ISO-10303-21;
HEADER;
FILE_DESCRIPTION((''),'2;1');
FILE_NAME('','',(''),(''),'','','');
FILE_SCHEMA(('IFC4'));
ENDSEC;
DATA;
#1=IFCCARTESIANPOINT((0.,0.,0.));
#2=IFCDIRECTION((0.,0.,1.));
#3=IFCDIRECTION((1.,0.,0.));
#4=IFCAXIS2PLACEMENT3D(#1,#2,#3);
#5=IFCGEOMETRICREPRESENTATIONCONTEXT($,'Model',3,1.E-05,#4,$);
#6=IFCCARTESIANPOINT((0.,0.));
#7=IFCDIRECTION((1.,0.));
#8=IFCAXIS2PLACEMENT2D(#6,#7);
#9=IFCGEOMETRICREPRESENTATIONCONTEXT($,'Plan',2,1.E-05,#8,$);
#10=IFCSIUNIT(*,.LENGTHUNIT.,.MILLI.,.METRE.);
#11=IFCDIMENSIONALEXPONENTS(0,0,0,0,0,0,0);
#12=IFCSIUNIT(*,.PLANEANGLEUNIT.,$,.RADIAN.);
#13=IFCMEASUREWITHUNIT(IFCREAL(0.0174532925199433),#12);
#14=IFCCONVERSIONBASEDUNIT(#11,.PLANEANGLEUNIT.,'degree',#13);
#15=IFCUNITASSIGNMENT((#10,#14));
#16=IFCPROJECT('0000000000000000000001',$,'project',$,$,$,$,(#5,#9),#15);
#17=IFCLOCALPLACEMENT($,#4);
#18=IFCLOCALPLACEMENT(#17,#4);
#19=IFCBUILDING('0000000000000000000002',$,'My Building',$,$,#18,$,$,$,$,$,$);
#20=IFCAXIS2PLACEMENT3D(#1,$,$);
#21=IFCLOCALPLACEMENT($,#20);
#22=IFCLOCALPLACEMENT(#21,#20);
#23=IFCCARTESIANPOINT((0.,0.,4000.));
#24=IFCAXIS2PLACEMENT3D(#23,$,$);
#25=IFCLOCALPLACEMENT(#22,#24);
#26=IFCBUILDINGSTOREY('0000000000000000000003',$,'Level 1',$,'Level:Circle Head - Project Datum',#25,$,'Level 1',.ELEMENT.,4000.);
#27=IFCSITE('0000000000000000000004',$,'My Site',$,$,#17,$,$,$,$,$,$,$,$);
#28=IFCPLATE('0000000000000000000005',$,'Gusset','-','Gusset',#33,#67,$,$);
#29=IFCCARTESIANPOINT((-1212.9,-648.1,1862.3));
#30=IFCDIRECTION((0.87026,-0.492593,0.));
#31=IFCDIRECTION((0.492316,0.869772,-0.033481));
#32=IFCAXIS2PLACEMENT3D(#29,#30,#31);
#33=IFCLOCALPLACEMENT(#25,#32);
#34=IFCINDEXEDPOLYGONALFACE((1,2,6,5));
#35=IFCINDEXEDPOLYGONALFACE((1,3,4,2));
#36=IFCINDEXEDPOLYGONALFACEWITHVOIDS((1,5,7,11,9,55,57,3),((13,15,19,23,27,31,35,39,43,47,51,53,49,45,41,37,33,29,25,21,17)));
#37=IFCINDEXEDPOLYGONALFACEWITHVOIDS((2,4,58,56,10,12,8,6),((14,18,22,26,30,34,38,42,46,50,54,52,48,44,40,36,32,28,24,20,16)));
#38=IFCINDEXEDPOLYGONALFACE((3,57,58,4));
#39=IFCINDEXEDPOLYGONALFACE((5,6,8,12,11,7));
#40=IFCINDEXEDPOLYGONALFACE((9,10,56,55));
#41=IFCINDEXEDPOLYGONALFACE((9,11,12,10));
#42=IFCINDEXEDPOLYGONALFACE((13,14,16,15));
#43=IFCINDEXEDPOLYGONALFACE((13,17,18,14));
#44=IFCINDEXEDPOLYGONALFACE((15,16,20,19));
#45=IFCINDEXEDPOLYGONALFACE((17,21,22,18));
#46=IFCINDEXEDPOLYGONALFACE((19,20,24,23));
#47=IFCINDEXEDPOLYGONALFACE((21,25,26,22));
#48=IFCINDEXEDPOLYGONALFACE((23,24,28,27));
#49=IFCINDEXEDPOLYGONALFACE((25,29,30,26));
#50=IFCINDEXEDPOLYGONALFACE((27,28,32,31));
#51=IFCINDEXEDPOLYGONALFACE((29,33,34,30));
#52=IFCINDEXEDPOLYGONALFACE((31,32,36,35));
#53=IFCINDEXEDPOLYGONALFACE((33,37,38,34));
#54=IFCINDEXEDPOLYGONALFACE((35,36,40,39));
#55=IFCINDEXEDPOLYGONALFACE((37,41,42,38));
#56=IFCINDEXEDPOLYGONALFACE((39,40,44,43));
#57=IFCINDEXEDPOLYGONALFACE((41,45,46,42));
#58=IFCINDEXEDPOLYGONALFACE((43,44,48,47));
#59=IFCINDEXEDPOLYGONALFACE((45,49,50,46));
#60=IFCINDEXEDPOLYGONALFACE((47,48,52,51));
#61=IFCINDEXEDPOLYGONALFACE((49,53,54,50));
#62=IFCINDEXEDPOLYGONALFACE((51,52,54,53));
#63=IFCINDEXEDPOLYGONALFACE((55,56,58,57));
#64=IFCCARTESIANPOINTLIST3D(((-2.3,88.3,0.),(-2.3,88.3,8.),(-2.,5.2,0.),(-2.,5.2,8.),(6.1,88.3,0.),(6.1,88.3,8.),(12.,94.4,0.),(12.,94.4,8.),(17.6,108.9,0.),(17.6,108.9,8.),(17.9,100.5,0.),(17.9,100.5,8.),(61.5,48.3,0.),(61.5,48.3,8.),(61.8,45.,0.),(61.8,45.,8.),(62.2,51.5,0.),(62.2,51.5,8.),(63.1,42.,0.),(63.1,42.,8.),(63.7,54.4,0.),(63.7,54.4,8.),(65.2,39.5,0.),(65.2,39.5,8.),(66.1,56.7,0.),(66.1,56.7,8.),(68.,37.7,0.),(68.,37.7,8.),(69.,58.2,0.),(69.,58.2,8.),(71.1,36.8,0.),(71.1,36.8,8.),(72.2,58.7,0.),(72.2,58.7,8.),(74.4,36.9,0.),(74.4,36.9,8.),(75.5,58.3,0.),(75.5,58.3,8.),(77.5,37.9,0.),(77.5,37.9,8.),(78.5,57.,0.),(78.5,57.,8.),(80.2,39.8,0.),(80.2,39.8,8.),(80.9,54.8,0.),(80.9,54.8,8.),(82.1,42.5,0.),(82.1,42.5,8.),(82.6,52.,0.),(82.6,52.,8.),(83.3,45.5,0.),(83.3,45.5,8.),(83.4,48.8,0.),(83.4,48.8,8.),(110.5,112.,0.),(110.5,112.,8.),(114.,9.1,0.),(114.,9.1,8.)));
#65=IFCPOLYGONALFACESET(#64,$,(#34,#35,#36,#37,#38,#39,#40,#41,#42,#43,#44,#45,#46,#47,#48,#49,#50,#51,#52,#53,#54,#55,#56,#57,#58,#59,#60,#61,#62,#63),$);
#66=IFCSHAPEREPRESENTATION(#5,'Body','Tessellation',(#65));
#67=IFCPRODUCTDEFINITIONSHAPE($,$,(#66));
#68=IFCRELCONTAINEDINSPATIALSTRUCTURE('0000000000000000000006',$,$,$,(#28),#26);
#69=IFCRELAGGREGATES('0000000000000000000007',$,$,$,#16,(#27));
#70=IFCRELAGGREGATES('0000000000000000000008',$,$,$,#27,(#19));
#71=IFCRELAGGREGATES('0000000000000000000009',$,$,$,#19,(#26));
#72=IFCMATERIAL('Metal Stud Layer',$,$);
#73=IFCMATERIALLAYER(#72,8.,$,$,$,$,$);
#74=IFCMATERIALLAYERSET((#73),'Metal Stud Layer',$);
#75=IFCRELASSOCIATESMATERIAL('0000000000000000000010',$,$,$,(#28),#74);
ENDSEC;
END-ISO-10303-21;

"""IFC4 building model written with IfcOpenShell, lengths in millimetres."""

from ifc_helpers import new_model, entity, si_unit, converted_unit, point, frame, frame_2d, origin, origin_with_axes, origin_2d_with_axis, place, context, project, spatial, polyline, circle_curve, line_curve, trimmed, segment, composite_curve, circle, outline, extrude, material, layer, layer_set, element, save


model = new_model("IFC4")

# Units and contexts
model_context = context("Model", 3, precision=1e-05, world=origin_with_axes())
plan_context = context("Plan", 2, precision=1e-05, world=origin_2d_with_axis())
ifc_project = project(units=[si_unit("LENGTHUNIT", "METRE", prefix="MILLI"), converted_unit("PLANEANGLEUNIT", "degree", entity("IfcReal", 0.0174532925199433), si_unit("PLANEANGLEUNIT", "RADIAN"), dimensions=[0, 0, 0, 0, 0, 0, 0])], contexts=[model_context, plan_context])

# Site, building, storey
site_placement = place(None, origin_with_axes())
site = spatial("IfcSite", under=ifc_project, at=site_placement, Name="My Site")
building_placement = place(site_placement, origin_with_axes())
building = spatial("IfcBuilding", under=site, at=building_placement, Name="My Building")
placement_1 = place(None, origin())
placement_2 = place(placement_1, origin())
storey_placement = place(placement_2, frame((0.0, 0.0, 4000.0)))
storey = spatial("IfcBuildingStorey", under=building, at=storey_placement, Name="Level 1", ObjectType="Level:Circle Head - Project Datum", LongName="Level 1", CompositionType="ELEMENT", Elevation=4000.0)

# Plate, openings
ifc_material_1 = material(Name="Metal Stud Layer")
ifc_layer_1 = layer(ifc_material_1, 8.0)
ifc_layer_set_1 = layer_set([ifc_layer_1], Name="Metal Stud Layer")
plate_1_placement = place(storey_placement, frame((-1212.9, -648.1, 1862.3), z_axis=(0.87026, -0.492593, 0.0), x_axis=(0.492316, 0.869772, -0.033481)))
plate_1 = element("IfcPlate", 1, at=plate_1_placement, inside=storey, material=ifc_layer_set_1, Name="Gusset", Description="-", ObjectType="Gusset", context=model_context, shape_type="SweptSolid", body=[
    extrude(outline(polyline([(114.0, 9.1), (110.5, 112.0), (17.6, 108.9), (17.9, 100.5), (6.1, 88.3), (-2.3, 88.3), (-2.0, 5.2), (114.0, 9.1)])), origin_with_axes(), (0.0, 0.0, 1.0), 8.0),
])
opening_1_placement = place(plate_1_placement, frame((72.5, 47.7, -0.5), z_axis=(0.0, 0.0, 1.0), x_axis=(0.877396, -0.479766, 0.0)))
element("IfcOpeningElement", 2, at=opening_1_placement, cuts=plate_1, ObjectType="Opening", context=model_context, shape_type="SweptSolid", body=[
    extrude(circle(Radius=11.0, at=origin_2d_with_axis()), origin(), (0.0, 0.0, 1.0), 9.0),
])
opening_2_placement = place(plate_1_placement, origin_with_axes())
element("IfcOpeningElement", 3, at=opening_2_placement, cuts=plate_1, ObjectType="Opening", context=model_context, shape_type="SweptSolid", body=[
    extrude(outline(composite_curve([segment(trimmed(line_curve((17.9, 100.5), (-0.693597, -0.720363), 8.455359), [point((17.9, 100.5))], [point((12.0, 94.4))], True, "CARTESIAN"), True, "CONTINUOUS"), segment(trimmed(circle_curve(frame_2d((-2.4, 108.3), x_axis=(1.0, 0.0)), 20.0), [point((12.0, 94.4))], [point((17.6, 108.9))], True, "CARTESIAN"), True, "CONTINUOUS"), segment(trimmed(line_curve((17.6, 108.9), (0.033481, -0.999439), 8.455359), [point((17.6, 108.9))], [point((17.9, 100.5))], True, "CARTESIAN"), True, "CONTINUOUS")], self_intersect=False)), origin(), (0.0, 0.0, 1.0), 8.0),
])
opening_3_placement = place(plate_1_placement, origin_with_axes())
element("IfcOpeningElement", 4, at=opening_3_placement, cuts=plate_1, ObjectType="Opening", context=model_context, shape_type="SweptSolid", body=[
    extrude(outline(composite_curve([segment(trimmed(line_curve((6.1, 88.3), (-0.99999, -0.004369), 8.455359), [point((6.1, 88.3))], [point((-2.3, 88.3))], True, "CARTESIAN"), True, "CONTINUOUS"), segment(trimmed(circle_curve(frame_2d((-2.4, 108.3), x_axis=(1.0, 0.0)), 20.0), [point((-2.3, 88.3))], [point((12.0, 94.4))], True, "CARTESIAN"), True, "CONTINUOUS"), segment(trimmed(line_curve((12.0, 94.4), (-0.693597, -0.720363), 8.455359), [point((12.0, 94.4))], [point((6.1, 88.3))], True, "CARTESIAN"), True, "CONTINUOUS")], self_intersect=False)), origin(), (0.0, 0.0, 1.0), 8.0),
])

save(model, "model.ifc")
